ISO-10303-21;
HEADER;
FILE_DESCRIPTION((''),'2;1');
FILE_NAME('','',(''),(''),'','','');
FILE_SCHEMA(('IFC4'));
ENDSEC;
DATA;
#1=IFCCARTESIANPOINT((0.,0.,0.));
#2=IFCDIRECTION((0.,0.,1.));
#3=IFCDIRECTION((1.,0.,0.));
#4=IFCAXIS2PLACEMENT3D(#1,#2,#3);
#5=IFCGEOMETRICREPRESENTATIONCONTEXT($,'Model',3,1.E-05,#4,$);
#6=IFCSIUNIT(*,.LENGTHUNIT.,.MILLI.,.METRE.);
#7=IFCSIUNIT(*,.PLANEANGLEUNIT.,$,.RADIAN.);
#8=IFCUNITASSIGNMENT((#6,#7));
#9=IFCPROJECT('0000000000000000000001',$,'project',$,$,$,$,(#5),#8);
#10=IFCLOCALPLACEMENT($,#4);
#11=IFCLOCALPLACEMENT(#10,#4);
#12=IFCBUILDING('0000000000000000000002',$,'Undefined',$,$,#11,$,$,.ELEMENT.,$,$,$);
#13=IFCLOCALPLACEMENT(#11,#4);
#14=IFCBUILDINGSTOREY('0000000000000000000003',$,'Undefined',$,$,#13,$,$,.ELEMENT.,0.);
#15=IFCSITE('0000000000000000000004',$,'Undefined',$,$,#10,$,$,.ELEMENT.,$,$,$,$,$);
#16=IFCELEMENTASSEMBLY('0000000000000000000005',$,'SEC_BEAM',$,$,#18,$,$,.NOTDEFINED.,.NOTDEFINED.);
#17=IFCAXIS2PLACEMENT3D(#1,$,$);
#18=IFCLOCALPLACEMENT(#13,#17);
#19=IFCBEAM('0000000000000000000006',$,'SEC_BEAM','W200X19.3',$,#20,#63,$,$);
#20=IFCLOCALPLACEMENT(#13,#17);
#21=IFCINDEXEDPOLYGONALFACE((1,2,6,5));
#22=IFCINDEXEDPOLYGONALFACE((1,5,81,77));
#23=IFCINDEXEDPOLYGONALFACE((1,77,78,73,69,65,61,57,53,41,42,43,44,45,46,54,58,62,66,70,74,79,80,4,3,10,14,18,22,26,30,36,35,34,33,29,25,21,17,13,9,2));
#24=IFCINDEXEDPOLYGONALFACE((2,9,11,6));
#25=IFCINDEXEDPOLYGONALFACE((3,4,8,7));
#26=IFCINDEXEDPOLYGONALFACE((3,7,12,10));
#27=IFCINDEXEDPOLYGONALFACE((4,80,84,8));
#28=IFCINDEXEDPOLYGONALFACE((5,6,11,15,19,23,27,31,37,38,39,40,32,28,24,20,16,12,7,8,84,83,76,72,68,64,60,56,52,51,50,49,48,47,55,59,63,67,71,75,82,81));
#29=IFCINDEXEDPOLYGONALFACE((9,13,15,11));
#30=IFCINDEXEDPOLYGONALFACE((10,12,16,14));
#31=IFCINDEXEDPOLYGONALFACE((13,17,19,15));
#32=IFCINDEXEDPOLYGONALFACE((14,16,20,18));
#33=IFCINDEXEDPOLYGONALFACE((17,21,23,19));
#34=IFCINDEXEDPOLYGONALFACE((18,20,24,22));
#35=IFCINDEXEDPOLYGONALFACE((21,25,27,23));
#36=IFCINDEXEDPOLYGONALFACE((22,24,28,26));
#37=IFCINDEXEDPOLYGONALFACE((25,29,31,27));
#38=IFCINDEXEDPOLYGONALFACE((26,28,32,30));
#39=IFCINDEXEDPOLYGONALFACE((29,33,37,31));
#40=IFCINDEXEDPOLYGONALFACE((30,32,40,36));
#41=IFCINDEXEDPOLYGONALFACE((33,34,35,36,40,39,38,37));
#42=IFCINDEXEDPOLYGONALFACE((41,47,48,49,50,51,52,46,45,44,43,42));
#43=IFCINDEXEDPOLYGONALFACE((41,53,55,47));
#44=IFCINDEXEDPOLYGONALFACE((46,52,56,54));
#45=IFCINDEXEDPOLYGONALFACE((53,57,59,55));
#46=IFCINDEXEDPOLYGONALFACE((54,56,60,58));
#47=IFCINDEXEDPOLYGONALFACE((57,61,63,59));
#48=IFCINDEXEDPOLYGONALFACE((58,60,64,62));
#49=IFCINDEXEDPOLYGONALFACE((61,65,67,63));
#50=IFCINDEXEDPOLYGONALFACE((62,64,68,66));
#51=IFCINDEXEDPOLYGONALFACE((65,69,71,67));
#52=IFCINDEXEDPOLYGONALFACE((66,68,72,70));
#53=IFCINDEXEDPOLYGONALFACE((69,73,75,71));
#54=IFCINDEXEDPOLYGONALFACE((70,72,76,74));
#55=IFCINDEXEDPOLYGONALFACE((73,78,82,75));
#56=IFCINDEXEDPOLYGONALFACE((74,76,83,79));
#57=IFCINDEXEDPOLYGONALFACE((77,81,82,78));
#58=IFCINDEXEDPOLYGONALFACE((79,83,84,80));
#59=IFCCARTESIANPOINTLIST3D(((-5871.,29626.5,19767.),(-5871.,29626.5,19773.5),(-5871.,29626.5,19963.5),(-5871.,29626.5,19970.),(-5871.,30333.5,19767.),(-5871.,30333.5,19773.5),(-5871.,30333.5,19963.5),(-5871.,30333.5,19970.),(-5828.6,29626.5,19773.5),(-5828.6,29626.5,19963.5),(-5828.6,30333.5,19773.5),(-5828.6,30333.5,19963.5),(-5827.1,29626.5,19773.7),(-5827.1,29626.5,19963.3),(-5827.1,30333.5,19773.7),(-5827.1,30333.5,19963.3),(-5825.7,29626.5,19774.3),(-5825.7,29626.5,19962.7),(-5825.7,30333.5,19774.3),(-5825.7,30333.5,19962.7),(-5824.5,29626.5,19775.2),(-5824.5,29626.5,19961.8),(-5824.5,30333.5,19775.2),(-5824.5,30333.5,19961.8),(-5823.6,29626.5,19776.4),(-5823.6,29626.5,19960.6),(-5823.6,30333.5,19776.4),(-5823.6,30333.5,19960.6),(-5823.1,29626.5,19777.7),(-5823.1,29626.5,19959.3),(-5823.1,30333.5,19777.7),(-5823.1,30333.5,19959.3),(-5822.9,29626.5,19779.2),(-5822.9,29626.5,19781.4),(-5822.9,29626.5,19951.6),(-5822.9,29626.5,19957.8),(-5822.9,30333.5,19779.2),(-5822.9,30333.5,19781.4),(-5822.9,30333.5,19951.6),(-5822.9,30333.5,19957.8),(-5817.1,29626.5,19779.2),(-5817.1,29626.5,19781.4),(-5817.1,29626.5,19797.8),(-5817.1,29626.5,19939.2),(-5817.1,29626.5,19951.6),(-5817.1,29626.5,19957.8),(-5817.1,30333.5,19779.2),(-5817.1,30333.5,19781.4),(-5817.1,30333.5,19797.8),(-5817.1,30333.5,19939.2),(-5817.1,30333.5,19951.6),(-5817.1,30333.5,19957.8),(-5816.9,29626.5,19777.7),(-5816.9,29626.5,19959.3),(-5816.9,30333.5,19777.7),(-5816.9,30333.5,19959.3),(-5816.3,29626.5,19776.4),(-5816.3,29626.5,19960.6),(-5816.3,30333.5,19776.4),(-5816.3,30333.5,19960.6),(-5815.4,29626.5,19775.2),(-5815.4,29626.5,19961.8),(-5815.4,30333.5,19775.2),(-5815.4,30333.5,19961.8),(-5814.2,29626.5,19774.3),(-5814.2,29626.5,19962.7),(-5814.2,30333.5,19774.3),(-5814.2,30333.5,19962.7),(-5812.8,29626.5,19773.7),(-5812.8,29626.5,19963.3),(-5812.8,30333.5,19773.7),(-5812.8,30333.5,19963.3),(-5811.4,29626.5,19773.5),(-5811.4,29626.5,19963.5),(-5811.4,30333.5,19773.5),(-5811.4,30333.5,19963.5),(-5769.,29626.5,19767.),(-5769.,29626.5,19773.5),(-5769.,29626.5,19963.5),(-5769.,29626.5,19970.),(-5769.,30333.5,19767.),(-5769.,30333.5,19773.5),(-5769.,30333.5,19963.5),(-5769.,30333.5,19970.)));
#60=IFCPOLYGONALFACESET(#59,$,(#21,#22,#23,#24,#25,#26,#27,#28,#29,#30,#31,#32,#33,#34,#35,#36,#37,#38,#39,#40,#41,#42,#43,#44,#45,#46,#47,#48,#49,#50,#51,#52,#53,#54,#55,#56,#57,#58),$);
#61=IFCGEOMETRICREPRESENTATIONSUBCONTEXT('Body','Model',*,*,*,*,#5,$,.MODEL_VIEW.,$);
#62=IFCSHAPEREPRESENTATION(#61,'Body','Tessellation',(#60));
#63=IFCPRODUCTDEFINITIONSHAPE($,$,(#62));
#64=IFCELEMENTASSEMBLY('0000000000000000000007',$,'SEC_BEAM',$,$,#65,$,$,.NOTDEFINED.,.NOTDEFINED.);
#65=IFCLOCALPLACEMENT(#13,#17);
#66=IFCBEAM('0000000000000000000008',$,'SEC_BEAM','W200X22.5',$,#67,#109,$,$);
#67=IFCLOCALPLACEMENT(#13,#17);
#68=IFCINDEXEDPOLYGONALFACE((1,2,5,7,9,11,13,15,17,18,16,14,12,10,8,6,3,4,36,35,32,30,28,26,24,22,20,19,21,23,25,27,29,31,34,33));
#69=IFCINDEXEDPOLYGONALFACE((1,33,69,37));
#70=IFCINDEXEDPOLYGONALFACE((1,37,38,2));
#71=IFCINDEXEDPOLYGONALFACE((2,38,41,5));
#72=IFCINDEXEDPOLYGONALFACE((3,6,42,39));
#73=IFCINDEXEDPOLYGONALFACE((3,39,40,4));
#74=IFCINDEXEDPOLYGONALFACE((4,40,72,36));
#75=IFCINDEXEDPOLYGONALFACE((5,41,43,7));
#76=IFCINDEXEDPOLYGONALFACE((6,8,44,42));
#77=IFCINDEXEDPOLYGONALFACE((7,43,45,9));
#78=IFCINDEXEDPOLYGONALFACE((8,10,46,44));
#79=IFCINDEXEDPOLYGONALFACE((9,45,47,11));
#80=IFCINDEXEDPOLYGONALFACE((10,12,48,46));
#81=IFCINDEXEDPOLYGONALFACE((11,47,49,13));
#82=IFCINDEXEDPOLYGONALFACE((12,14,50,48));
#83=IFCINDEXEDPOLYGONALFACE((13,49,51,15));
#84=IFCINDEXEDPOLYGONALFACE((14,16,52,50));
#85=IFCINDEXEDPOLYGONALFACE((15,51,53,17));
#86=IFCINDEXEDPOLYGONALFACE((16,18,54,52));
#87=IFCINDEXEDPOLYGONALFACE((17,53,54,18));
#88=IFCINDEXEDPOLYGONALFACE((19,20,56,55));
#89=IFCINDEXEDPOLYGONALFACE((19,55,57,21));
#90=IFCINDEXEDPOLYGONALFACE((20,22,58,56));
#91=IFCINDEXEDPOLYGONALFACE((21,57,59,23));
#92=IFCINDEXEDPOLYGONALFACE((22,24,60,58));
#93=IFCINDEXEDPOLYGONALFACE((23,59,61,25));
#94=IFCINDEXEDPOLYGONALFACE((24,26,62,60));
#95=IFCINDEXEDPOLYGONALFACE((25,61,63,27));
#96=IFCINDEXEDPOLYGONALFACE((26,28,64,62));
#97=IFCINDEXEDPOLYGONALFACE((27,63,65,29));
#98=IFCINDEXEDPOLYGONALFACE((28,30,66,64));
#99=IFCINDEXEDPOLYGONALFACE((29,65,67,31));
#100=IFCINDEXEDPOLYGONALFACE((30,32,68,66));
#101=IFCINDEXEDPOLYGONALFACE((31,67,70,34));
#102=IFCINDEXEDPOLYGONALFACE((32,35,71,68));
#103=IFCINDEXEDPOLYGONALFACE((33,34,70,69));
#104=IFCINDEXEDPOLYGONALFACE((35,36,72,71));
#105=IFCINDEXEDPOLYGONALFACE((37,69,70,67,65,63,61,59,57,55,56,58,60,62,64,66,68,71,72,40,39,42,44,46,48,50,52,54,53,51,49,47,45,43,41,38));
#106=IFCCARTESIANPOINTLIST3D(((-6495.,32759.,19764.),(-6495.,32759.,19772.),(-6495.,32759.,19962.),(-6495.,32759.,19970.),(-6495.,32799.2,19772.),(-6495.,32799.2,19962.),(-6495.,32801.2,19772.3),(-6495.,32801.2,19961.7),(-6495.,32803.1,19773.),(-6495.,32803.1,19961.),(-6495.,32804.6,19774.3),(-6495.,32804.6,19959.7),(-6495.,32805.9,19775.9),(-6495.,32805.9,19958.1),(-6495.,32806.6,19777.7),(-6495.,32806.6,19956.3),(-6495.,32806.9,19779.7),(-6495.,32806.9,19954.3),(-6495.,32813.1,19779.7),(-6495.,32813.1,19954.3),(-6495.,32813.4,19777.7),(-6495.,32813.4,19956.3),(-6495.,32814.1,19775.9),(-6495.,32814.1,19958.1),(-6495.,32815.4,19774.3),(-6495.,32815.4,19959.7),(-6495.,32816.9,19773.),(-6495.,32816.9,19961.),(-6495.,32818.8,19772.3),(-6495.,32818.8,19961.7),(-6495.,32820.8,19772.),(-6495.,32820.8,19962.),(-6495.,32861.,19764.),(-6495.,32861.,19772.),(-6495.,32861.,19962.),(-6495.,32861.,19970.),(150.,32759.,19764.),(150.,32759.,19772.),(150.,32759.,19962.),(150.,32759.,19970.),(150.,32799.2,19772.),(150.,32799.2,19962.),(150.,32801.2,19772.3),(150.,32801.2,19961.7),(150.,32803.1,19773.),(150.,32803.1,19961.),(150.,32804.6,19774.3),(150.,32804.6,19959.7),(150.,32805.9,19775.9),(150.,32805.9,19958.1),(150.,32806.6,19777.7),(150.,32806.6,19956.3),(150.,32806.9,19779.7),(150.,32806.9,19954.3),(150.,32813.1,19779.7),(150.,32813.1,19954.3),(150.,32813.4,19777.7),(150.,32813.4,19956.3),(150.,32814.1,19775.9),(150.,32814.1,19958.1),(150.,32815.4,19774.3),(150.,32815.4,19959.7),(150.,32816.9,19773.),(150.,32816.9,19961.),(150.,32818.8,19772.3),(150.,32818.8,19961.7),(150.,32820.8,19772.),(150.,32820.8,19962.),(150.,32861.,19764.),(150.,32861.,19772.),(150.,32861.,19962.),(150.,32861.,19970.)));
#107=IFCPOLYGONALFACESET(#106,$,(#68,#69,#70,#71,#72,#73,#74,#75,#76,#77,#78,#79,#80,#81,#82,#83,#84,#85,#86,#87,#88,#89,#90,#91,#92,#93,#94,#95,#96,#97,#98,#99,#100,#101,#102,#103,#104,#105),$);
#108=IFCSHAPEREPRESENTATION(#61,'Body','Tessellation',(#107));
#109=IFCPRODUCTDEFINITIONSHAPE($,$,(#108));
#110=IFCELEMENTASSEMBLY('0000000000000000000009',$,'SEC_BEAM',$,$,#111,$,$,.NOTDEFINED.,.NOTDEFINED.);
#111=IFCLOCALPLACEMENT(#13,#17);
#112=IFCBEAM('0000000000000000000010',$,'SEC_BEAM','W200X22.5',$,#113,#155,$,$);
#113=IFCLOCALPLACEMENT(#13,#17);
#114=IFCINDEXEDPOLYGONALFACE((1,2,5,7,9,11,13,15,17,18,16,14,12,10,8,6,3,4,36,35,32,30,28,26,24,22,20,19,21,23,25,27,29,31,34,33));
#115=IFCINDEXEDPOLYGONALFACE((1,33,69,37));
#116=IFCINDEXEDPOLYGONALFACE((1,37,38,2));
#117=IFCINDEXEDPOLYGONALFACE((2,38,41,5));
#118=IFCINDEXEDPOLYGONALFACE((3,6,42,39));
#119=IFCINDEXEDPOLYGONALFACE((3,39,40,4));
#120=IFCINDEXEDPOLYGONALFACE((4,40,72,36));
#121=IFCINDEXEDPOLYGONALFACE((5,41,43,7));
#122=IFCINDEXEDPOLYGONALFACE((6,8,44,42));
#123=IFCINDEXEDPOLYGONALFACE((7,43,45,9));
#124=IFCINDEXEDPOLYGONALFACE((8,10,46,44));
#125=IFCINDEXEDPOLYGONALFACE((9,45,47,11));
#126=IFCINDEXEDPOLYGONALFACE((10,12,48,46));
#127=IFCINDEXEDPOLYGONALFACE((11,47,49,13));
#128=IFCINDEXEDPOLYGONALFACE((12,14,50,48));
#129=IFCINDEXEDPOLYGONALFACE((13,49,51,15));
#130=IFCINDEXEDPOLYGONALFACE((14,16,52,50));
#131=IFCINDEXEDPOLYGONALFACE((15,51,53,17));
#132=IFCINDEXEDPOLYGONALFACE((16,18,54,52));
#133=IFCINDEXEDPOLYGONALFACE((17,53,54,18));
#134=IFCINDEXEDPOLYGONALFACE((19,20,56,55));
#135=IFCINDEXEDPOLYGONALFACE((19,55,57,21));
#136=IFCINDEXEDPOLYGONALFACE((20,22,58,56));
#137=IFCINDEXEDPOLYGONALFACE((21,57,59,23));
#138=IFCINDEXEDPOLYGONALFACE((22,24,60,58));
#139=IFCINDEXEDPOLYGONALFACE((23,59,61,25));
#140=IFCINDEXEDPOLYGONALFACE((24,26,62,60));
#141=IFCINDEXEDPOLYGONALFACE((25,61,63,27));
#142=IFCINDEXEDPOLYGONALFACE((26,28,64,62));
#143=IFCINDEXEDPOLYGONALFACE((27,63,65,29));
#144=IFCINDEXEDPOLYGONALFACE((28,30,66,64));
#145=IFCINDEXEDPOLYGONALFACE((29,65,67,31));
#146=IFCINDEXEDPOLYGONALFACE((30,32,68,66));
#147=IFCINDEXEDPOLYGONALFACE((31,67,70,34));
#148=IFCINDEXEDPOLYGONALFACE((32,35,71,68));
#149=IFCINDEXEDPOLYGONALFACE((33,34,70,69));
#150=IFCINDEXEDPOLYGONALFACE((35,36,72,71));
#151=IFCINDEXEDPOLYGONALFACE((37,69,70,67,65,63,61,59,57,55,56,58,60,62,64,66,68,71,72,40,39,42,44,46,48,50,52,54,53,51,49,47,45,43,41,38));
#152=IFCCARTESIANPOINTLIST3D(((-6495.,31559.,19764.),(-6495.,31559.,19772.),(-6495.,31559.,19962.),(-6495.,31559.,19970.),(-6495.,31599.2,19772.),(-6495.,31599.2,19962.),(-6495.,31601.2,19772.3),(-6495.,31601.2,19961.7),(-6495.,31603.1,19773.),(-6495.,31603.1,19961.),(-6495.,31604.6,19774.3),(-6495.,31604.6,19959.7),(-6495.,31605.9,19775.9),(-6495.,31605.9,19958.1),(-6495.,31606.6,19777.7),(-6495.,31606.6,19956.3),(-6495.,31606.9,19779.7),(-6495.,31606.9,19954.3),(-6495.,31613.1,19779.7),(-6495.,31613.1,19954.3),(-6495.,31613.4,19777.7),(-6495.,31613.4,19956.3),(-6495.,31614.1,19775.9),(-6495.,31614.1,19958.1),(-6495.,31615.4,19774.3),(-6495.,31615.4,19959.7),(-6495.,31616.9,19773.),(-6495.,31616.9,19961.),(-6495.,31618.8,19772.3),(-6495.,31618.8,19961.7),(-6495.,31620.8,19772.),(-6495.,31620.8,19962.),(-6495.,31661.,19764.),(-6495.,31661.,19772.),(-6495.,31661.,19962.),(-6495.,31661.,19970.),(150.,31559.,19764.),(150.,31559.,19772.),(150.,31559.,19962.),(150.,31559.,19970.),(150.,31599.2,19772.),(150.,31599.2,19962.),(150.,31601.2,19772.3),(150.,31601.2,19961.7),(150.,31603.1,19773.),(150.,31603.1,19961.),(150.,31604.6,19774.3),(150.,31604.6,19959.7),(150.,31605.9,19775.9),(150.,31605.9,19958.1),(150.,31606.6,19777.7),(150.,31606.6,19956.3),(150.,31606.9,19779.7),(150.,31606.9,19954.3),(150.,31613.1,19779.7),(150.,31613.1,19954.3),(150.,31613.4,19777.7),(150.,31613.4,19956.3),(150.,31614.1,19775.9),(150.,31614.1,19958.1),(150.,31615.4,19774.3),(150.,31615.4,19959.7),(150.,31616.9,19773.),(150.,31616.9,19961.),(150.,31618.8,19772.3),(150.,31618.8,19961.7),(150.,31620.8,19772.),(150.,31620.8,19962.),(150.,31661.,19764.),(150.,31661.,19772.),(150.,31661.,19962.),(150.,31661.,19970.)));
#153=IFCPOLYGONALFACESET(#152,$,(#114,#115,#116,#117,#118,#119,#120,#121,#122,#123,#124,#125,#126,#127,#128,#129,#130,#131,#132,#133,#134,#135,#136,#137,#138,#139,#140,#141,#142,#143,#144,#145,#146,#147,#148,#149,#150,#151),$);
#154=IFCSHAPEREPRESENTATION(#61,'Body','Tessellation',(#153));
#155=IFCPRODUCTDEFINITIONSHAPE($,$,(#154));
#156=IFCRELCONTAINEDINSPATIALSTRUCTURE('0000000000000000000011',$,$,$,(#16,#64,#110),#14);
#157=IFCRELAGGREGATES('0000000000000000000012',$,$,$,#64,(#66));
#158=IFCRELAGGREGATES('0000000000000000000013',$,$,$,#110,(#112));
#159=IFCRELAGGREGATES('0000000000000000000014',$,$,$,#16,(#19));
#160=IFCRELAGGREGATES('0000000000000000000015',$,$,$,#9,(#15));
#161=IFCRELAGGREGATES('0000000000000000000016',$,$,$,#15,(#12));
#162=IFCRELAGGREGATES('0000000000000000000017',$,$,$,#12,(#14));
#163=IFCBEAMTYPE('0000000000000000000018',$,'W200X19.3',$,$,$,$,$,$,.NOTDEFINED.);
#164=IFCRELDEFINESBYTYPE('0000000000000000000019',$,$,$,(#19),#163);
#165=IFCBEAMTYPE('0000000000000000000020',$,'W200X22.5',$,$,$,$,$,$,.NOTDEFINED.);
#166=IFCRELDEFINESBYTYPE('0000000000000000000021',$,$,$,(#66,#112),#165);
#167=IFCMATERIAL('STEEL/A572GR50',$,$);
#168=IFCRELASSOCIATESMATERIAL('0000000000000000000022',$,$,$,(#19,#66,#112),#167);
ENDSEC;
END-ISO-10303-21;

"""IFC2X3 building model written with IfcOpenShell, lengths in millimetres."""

from ifc_helpers import new_model, si_unit, frame, origin_with_axes, origin_2d_with_axis, place, context, subcontext, project, spatial, polyline, rectangle, i_section, outline, extrude, boolean, clip, halfspace, material, type_object, element, aggregate, save


model = new_model("IFC2X3")

# Units and contexts
model_context = context("Model", 3, precision=1e-05, world=origin_with_axes())
body_context = subcontext(model_context, "Body", "Model", "MODEL_VIEW")
ifc_project = project(units=[si_unit("LENGTHUNIT", "METRE", prefix="MILLI"), si_unit("PLANEANGLEUNIT", "RADIAN")], contexts=[model_context])

# Site, building, storey
site_placement = place(None, origin_with_axes())
site = spatial("IfcSite", under=ifc_project, at=site_placement, Name="Undefined", CompositionType="ELEMENT")
building_placement = place(site_placement, origin_with_axes())
building = spatial("IfcBuilding", under=site, at=building_placement, Name="Undefined", CompositionType="ELEMENT")
storey_placement = place(building_placement, origin_with_axes())
storey = spatial("IfcBuildingStorey", under=building, at=storey_placement, Name="Undefined", CompositionType="ELEMENT", Elevation=0.0)

# Element assemblies, beams
ifc_material_1 = material(Name="STEEL/A572GR50")
beam_type_1 = type_object("IfcBeamType", Name="W200X19.3", PredefinedType="NOTDEFINED")
assembly_1_placement = place(storey_placement, origin_with_axes())
assembly_1 = element("IfcElementAssembly", 1, at=assembly_1_placement, inside=storey, Name="SEC_BEAM", AssemblyPlace="NOTDEFINED", PredefinedType="NOTDEFINED")
beam_1_placement = place(assembly_1_placement, frame((-5820.0, 30410.0, 19868.5), z_axis=(0.0, 0.0, 1.0), x_axis=(0.0, -1.0, 0.0)))
beam_1 = element("IfcBeam", 2, at=beam_1_placement, type_object=beam_type_1, material=ifc_material_1, Name="SEC_BEAM", Description="W200X19.3", context=body_context, shape_type="CSG", body=[
    boolean("DIFFERENCE", boolean("DIFFERENCE", boolean("DIFFERENCE", boolean("DIFFERENCE", boolean("DIFFERENCE", boolean("DIFFERENCE", boolean("DIFFERENCE", boolean("DIFFERENCE", extrude(i_section(OverallWidth=102.0, OverallDepth=203.0, WebThickness=5.8, FlangeThickness=6.5, FilletRadius=5.7, at=origin_2d_with_axis()), frame((860.0, 0.0, 0.0), z_axis=(-1.0, 0.0, 0.0), x_axis=(0.0, -1.0, 0.0)), (0.0, 0.0, 1.0), 860.0), extrude(outline(polyline([(0.0, 0.0), (24.4, 0.0), (24.4, 10.0), (0.0, 10.0), (0.0, 0.0)])), frame((783.5, 61.0, -87.1), z_axis=(0.0, -1.0, 0.0), x_axis=(0.0, 0.0, -1.0)), (0.0, 0.0, 1.0), 122.0)), extrude(outline(polyline([(0.0, 0.0), (28.4, 0.0), (28.4, 10.0), (0.0, 10.0), (0.0, 0.0)])), frame((783.5, -61.0, 83.1), z_axis=(0.0, 1.0, 0.0), x_axis=(0.0, 0.0, 1.0)), (0.0, 0.0, 1.0), 122.0)), extrude(rectangle(XDim=143.6, YDim=143.6, at=origin_2d_with_axis()), frame((785.3, 74.7, 70.7), z_axis=(0.0, 0.0, -1.0), x_axis=(-1.0, 0.0, 0.0)), (0.0, 0.0, 1.0), 141.5)), extrude(outline(polyline([(0.0, 0.0), (28.4, 0.0), (28.4, 10.0), (0.0, 10.0), (0.0, 0.0)])), frame((76.5, 61.0, 83.1), z_axis=(0.0, -1.0, 0.0), x_axis=(0.0, 0.0, 1.0)), (0.0, 0.0, 1.0), 122.0)), extrude(outline(polyline([(0.0, 0.0), (24.4, 0.0), (24.4, 10.0), (0.0, 10.0), (0.0, 0.0)])), frame((76.5, -61.0, -87.1), z_axis=(0.0, 1.0, 0.0), x_axis=(0.0, 0.0, -1.0)), (0.0, 0.0, 1.0), 122.0)), extrude(rectangle(XDim=143.6, YDim=143.6, at=origin_2d_with_axis()), frame((74.7, 74.7, 70.7), z_axis=(0.0, 0.0, -1.0), x_axis=(1.0, 0.0, 0.0)), (0.0, 0.0, 1.0), 141.5)), halfspace(frame((783.5, 0.0, 201.5), z_axis=(1.0, 0.0, 0.0), x_axis=(0.0, 1.0, 0.0)), False)), halfspace(frame((76.5, 0.0, 201.5), z_axis=(-1.0, 0.0, 0.0), x_axis=(0.0, -1.0, 0.0)), False)),
])
assembly_2_placement = place(storey_placement, origin_with_axes())
assembly_2 = element("IfcElementAssembly", 3, at=assembly_2_placement, inside=storey, Name="SEC_BEAM", AssemblyPlace="NOTDEFINED", PredefinedType="NOTDEFINED")
beam_type_2 = type_object("IfcBeamType", Name="W200X22.5", PredefinedType="NOTDEFINED")
beam_2_placement = place(assembly_2_placement, frame((0.0, 32810.0, 19867.0), z_axis=(0.0, 0.0, 1.0), x_axis=(-1.0, 0.0, 0.0)))
beam_2 = element("IfcBeam", 4, at=beam_2_placement, type_object=beam_type_2, material=ifc_material_1, Name="SEC_BEAM", Description="W200X22.5", context=body_context, shape_type="Clipping", body=[
    clip(clip(extrude(i_section(OverallWidth=102.0, OverallDepth=206.0, WebThickness=6.2, FlangeThickness=8.0, FilletRadius=7.7, at=origin_2d_with_axis()), frame((6500.0, 0.0, 0.0), z_axis=(-1.0, 0.0, 0.0), x_axis=(0.0, -1.0, 0.0)), (0.0, 0.0, 1.0), 6650.0), halfspace(frame((6495.0, 0.0, 0.0), z_axis=(-1.0, 0.0, 0.0), x_axis=(0.0, 1.0, 0.0)), True)), halfspace(frame((-150.0, 0.0, 0.0), z_axis=(1.0, 0.0, 0.0), x_axis=(0.0, -1.0, 0.0)), True)),
])
assembly_3_placement = place(storey_placement, origin_with_axes())
assembly_3 = element("IfcElementAssembly", 5, at=assembly_3_placement, inside=storey, Name="SEC_BEAM", AssemblyPlace="NOTDEFINED", PredefinedType="NOTDEFINED")
beam_3_placement = place(assembly_3_placement, frame((0.0, 31610.0, 19867.0), z_axis=(0.0, 0.0, 1.0), x_axis=(-1.0, 0.0, 0.0)))
beam_3 = element("IfcBeam", 6, at=beam_3_placement, type_object=beam_type_2, material=ifc_material_1, Name="SEC_BEAM", Description="W200X22.5", context=body_context, shape_type="Clipping", body=[
    clip(clip(extrude(i_section(OverallWidth=102.0, OverallDepth=206.0, WebThickness=6.2, FlangeThickness=8.0, FilletRadius=7.7, at=origin_2d_with_axis()), frame((6500.0, 0.0, 0.0), z_axis=(-1.0, 0.0, 0.0), x_axis=(0.0, -1.0, 0.0)), (0.0, 0.0, 1.0), 6650.0), halfspace(frame((6495.0, 0.0, 0.0), z_axis=(-1.0, 0.0, 0.0), x_axis=(0.0, 1.0, 0.0)), True)), halfspace(frame((-150.0, 0.0, 0.0), z_axis=(1.0, 0.0, 0.0), x_axis=(0.0, -1.0, 0.0)), True)),
])

aggregate(assembly_2, [beam_2])
aggregate(assembly_3, [beam_3])
aggregate(assembly_1, [beam_1])

save(model, "model.ifc")
